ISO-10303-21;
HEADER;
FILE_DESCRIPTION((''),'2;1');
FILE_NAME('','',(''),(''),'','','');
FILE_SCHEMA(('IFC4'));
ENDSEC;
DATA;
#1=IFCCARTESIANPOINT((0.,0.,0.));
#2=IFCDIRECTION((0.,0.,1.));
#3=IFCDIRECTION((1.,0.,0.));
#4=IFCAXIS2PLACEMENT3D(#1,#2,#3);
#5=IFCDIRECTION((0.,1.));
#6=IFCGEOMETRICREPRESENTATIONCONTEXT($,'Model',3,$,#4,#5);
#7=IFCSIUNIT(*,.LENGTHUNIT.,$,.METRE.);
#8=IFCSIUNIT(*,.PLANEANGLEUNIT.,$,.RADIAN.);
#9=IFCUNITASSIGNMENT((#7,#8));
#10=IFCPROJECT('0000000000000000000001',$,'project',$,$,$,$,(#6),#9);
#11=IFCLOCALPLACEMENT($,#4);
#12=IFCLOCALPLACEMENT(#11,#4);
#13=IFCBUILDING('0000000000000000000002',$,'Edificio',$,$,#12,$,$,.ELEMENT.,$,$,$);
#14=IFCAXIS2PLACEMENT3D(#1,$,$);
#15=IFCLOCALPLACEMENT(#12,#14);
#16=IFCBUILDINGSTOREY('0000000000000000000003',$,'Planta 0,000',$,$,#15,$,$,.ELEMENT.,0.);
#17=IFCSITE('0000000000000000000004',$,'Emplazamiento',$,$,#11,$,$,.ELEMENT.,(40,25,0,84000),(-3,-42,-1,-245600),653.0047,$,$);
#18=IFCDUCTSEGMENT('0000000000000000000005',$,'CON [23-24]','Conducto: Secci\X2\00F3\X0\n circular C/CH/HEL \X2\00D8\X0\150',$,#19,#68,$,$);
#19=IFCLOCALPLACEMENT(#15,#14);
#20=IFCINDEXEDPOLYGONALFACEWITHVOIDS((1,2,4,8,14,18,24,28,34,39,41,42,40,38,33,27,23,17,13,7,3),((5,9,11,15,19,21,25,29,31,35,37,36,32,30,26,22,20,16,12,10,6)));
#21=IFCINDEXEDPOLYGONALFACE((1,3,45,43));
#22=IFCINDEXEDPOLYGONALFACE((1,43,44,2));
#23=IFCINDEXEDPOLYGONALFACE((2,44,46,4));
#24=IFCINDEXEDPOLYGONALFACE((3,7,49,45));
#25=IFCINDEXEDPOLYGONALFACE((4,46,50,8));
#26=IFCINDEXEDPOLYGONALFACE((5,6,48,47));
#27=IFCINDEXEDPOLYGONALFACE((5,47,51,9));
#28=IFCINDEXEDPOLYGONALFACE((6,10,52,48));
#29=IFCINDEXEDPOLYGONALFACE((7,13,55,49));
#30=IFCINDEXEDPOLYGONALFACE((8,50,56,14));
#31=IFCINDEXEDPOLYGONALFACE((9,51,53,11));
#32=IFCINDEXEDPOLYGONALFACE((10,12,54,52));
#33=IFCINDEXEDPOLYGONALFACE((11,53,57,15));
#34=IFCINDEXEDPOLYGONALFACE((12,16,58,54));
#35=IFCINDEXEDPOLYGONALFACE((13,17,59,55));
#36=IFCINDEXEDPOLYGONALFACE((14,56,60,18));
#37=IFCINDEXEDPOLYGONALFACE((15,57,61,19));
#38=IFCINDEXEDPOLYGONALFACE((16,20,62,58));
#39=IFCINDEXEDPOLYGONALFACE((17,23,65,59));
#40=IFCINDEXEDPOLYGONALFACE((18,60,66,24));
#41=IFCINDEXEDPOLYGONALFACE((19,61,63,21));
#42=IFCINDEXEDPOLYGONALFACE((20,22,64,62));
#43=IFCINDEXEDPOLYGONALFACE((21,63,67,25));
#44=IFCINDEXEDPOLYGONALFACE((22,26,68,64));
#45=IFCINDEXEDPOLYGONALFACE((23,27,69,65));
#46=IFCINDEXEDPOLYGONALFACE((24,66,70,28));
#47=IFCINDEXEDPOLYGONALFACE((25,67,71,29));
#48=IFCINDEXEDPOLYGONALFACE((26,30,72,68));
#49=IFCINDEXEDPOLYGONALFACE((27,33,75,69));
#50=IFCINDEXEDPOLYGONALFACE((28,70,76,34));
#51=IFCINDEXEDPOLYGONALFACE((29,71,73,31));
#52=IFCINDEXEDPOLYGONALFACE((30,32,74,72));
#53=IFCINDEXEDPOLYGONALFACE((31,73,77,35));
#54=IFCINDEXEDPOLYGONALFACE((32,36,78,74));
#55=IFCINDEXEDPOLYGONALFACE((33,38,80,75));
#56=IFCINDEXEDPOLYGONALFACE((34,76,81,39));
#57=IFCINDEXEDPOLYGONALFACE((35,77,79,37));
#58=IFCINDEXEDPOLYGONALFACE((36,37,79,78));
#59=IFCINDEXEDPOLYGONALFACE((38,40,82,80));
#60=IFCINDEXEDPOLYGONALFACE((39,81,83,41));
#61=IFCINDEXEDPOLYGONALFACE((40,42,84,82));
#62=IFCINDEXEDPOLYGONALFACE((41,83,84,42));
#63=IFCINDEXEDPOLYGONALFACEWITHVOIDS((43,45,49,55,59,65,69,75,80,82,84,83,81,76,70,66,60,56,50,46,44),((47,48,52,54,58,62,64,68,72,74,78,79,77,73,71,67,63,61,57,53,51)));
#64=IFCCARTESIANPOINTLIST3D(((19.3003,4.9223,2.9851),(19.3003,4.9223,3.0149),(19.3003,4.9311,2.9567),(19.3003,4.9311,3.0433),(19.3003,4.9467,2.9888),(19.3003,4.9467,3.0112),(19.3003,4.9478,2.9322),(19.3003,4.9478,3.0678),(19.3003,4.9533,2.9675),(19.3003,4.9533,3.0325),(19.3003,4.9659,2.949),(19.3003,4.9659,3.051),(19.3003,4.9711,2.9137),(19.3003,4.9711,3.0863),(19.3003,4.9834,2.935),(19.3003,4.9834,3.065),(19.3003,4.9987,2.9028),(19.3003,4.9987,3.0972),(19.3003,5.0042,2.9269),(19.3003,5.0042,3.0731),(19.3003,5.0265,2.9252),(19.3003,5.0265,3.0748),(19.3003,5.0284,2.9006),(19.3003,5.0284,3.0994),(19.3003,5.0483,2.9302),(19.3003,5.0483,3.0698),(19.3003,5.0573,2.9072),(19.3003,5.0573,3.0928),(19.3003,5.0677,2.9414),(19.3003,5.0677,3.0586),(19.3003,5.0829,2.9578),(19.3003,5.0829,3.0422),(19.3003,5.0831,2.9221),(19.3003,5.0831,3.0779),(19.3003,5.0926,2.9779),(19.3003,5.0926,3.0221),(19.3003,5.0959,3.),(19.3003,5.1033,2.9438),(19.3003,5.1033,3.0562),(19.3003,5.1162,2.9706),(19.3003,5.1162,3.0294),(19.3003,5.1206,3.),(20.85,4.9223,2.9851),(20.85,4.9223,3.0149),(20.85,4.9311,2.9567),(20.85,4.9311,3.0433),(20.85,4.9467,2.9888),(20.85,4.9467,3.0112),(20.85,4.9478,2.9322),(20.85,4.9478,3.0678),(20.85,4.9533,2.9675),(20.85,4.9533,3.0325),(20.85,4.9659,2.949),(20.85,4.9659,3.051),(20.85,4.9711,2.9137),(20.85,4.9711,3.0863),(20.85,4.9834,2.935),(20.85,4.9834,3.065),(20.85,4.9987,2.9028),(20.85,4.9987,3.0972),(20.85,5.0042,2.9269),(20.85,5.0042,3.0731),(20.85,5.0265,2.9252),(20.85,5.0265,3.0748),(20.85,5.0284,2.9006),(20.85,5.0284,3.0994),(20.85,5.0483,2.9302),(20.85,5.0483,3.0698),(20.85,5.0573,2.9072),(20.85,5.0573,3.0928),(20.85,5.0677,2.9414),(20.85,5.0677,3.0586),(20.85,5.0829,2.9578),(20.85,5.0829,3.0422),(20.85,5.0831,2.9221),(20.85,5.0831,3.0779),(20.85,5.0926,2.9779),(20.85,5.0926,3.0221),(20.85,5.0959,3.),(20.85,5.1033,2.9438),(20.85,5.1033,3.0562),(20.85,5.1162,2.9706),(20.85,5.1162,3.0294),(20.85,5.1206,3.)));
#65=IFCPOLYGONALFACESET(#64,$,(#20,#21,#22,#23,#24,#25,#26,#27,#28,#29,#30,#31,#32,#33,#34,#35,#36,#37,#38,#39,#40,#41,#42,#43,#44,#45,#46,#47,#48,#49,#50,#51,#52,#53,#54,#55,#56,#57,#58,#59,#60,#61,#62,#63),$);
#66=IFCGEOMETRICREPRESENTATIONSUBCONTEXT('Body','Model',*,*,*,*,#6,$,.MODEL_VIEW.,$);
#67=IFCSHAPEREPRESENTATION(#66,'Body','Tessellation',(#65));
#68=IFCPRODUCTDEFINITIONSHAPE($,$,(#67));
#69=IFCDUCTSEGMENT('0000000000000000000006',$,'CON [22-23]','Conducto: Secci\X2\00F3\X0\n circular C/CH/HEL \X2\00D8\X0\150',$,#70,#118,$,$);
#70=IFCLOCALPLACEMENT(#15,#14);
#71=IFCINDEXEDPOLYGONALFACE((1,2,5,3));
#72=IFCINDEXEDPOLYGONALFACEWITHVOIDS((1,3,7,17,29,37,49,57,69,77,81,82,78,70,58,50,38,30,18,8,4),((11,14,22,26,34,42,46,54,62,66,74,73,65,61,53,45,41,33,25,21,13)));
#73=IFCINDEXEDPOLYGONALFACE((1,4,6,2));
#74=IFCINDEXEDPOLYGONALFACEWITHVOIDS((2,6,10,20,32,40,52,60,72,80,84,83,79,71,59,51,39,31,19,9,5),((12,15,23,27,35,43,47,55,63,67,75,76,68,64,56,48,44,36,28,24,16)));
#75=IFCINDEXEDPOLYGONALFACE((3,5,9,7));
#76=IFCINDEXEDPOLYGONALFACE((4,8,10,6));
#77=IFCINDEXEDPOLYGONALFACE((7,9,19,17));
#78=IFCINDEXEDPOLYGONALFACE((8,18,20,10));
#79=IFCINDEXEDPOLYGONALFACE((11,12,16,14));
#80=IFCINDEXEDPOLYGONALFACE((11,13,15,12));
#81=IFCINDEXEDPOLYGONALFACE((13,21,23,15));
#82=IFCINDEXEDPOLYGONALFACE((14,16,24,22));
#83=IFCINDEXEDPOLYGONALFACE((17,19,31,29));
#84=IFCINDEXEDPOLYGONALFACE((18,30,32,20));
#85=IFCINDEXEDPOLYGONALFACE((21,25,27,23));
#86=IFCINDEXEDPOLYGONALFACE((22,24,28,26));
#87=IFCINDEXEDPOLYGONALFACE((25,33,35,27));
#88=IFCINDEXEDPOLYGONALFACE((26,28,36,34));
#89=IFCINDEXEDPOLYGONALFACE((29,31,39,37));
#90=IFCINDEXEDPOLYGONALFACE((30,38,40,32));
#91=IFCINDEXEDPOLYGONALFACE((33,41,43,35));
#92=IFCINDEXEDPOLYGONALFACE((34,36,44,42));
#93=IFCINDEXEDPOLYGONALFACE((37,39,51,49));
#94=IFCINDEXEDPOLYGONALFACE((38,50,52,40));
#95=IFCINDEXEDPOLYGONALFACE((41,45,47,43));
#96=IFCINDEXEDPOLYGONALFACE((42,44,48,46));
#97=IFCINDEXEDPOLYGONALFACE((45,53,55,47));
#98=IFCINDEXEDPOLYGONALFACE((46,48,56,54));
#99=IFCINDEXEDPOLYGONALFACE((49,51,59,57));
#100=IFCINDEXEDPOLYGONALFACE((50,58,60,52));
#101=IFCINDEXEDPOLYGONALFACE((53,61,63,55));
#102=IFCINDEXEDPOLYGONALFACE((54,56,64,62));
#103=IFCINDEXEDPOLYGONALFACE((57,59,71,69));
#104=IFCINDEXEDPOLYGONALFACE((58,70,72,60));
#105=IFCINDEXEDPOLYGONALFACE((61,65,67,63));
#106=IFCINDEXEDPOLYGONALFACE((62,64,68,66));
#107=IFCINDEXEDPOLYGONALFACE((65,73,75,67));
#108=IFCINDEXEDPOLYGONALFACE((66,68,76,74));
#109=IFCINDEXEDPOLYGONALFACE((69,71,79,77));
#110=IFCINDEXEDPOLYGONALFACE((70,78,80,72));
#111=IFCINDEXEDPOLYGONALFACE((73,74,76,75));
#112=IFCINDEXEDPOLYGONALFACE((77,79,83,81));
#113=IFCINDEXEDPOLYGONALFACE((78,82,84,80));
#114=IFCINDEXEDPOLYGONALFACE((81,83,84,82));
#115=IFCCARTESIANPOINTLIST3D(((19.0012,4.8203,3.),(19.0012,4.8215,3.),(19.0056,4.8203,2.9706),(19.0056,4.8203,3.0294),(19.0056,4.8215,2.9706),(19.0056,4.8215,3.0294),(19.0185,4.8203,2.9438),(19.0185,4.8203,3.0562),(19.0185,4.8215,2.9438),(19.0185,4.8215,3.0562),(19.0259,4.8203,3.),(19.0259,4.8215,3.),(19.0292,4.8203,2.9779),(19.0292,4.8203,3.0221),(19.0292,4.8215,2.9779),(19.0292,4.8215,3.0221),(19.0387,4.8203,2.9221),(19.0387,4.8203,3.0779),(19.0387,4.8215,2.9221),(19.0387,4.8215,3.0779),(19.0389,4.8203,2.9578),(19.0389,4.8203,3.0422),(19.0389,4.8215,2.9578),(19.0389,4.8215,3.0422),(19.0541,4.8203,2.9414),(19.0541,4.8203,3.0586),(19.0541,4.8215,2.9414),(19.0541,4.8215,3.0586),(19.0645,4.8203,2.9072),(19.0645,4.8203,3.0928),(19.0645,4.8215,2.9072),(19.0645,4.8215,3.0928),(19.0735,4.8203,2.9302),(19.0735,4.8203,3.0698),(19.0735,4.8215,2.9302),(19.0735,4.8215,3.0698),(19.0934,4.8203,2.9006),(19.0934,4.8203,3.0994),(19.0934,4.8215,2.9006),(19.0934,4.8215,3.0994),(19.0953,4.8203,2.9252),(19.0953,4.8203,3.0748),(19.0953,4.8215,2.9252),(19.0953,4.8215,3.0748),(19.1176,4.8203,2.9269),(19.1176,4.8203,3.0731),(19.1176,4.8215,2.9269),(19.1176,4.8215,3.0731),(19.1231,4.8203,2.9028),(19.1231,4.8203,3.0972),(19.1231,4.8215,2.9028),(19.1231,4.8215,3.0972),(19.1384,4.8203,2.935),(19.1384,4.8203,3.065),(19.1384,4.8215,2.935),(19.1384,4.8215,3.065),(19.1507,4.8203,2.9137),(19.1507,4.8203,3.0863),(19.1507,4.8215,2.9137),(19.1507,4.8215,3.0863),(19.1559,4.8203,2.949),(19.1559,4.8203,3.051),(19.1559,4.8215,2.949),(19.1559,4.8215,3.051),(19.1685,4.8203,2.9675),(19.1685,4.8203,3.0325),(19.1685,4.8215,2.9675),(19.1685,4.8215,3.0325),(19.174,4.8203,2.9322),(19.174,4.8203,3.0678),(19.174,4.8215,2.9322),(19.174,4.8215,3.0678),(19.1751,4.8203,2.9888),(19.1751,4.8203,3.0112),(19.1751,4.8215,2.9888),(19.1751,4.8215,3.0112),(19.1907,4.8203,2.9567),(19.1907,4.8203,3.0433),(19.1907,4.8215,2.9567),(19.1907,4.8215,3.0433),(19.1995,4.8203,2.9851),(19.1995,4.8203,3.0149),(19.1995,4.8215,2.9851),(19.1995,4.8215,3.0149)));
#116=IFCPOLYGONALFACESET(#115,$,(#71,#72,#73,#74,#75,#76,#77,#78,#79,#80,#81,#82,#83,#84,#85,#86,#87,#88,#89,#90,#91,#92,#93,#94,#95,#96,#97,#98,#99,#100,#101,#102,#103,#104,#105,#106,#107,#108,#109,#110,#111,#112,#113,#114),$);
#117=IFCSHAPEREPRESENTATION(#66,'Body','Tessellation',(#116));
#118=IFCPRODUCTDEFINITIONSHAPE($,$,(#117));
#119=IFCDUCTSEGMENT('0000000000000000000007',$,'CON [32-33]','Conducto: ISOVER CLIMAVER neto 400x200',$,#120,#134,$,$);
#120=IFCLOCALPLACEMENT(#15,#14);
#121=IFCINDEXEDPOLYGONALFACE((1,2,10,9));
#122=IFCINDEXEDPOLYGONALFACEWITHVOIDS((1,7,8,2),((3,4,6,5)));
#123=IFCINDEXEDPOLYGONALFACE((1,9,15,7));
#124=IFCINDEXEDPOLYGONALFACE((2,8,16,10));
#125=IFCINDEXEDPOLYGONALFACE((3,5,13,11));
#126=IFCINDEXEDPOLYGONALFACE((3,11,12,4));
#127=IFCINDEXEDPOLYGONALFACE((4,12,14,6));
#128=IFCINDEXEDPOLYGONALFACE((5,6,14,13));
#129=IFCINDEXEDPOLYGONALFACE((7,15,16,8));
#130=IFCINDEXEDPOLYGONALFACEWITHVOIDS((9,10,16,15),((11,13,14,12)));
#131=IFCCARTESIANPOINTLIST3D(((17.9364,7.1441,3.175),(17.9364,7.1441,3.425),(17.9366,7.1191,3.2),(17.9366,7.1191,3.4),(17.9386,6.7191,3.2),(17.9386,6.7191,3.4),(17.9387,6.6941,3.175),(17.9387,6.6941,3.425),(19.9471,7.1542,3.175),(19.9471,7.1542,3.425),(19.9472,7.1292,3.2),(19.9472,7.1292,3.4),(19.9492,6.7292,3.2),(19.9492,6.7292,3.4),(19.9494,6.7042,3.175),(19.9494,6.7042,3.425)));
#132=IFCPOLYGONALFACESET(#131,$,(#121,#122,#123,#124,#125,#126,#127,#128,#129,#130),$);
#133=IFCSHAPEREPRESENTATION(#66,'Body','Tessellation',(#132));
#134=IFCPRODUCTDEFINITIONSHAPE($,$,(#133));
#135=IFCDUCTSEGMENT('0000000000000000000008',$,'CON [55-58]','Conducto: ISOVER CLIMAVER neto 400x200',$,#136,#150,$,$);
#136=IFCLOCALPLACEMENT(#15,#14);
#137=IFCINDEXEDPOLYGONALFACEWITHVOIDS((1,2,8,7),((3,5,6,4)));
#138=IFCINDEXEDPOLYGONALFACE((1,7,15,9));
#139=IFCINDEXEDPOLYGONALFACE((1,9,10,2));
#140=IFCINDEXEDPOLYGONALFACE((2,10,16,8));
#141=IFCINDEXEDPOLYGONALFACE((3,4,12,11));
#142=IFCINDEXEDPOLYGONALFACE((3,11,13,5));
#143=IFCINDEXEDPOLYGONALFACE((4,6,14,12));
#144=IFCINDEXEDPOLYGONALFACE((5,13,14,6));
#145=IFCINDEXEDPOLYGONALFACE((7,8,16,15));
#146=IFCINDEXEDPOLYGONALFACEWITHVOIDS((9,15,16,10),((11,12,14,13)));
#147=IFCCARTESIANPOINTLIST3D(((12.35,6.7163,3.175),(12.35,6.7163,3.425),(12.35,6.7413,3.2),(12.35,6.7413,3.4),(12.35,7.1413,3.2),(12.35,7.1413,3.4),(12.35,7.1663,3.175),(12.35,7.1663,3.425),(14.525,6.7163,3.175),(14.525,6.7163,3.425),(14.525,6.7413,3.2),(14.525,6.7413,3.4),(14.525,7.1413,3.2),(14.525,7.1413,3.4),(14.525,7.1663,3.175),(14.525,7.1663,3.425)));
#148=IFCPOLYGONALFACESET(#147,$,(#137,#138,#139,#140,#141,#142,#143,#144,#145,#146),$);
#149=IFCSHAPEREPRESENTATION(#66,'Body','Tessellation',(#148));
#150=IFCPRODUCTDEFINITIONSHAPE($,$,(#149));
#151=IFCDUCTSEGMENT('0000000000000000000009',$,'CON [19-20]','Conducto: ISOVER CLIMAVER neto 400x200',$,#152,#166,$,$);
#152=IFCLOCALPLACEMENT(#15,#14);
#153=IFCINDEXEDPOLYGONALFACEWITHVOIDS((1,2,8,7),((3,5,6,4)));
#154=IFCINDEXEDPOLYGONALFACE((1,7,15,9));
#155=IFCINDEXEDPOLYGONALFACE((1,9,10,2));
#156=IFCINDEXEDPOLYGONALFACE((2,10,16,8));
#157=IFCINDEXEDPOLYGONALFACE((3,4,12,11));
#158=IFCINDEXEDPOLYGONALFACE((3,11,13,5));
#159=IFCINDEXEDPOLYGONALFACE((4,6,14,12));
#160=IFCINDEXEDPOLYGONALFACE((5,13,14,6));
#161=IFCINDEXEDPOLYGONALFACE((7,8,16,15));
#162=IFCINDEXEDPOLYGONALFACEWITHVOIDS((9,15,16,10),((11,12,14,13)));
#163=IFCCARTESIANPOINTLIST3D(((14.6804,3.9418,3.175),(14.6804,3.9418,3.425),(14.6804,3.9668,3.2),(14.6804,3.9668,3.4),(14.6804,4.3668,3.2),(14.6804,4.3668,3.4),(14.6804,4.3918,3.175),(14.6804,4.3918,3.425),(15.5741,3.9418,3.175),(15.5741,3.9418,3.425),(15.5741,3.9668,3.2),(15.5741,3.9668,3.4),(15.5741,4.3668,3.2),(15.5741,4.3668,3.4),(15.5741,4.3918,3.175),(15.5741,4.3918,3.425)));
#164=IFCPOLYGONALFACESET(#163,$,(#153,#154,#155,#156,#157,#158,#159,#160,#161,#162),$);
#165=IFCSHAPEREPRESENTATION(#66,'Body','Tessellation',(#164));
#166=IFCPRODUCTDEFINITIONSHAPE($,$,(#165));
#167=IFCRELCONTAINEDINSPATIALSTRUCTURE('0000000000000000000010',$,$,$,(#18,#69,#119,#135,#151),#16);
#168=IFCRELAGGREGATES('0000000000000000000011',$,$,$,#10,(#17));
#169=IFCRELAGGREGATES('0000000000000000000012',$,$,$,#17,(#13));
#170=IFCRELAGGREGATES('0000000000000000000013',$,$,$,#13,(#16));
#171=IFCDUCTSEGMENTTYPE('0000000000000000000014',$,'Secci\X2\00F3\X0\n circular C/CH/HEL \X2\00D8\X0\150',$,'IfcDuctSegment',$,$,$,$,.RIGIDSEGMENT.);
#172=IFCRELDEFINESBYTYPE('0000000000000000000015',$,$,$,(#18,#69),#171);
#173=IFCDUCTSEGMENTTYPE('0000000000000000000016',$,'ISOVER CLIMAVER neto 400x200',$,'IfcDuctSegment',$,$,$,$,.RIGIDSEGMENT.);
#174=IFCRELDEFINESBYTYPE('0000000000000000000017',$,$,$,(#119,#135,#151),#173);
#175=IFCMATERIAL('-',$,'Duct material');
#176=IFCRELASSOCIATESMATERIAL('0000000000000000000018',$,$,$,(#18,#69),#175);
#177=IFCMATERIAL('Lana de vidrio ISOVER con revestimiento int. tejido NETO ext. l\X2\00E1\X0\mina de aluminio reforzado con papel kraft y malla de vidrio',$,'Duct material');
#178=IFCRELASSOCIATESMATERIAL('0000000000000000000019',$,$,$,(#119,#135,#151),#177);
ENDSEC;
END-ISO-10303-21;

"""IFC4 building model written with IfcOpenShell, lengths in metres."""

from ifc_helpers import new_model, si_unit, direction, frame, origin, origin_with_axes, origin_2d_with_axis, place, context, subcontext, project, spatial, hollow_rectangle, hollow_circle, extrude, material, type_object, element, save


model = new_model("IFC4")

# Units and contexts
model_context = context("Model", 3, world=origin_with_axes(), true_north=direction((0.0, 1.0)))
body_context = subcontext(model_context, "Body", "Model", "MODEL_VIEW")
ifc_project = project(units=[si_unit("LENGTHUNIT", "METRE"), si_unit("PLANEANGLEUNIT", "RADIAN")], contexts=[model_context])

# Site, building, storey
site_placement = place(None, origin_with_axes())
site = spatial("IfcSite", under=ifc_project, at=site_placement, Name="Emplazamiento", CompositionType="ELEMENT", RefLatitude=(40, 25, 0, 84000), RefLongitude=(-3, -42, -1, -245600), RefElevation=653.0047)
building_placement = place(site_placement, origin_with_axes())
building = spatial("IfcBuilding", under=site, at=building_placement, Name="Edificio", CompositionType="ELEMENT")
storey_placement = place(building_placement, origin())
storey = spatial("IfcBuildingStorey", under=building, at=storey_placement, Name="Planta 0,000", CompositionType="ELEMENT", Elevation=0.0)

# Shared definitions
ifc_material_1 = material(Name="-", Category="Duct material")

# Shared definitions
ifc_material_2 = material(Name="Lana de vidrio ISOVER con revestimiento int. tejido NETO ext. lámina de aluminio reforzado con papel kraft y malla de vidrio", Category="Duct material")

# Duct segments
duct_segment_type_1 = type_object("IfcDuctSegmentType", Name="Sección circular C/CH/HEL Ø150", ApplicableOccurrence="IfcDuctSegment", PredefinedType="RIGIDSEGMENT")
duct_segment_1_placement = place(storey_placement, origin_with_axes())
element("IfcDuctSegment", 1, at=duct_segment_1_placement, inside=storey, type_object=duct_segment_type_1, material=ifc_material_1, Name="CON [23-24]", Description="Conducto: Sección circular C/CH/HEL Ø150", context=body_context, shape_type="SweptSolid", body=[
    extrude(hollow_circle(Radius=0.0997, WallThickness=0.0247, at=origin_2d_with_axis()), frame((19.3003, 5.0209, 3.0), z_axis=(1.0, 0.0, 0.0), x_axis=(0.0, 1.0, 0.0)), (0.0, 0.0, 1.0), 1.5497),
])
duct_segment_2_placement = place(storey_placement, origin_with_axes())
element("IfcDuctSegment", 2, at=duct_segment_2_placement, inside=storey, type_object=duct_segment_type_1, material=ifc_material_1, Name="CON [22-23]", Description="Conducto: Sección circular C/CH/HEL Ø150", context=body_context, shape_type="SweptSolid", body=[
    extrude(hollow_circle(Radius=0.0997, WallThickness=0.0247, at=origin_2d_with_axis()), frame((19.1009, 4.8203, 3.0), z_axis=(0.0, 1.0, 0.0), x_axis=(-1.0, 0.0, 0.0)), (0.0, 0.0, 1.0), 0.0012),
])
duct_segment_type_2 = type_object("IfcDuctSegmentType", Name="ISOVER CLIMAVER neto 400x200", ApplicableOccurrence="IfcDuctSegment", PredefinedType="RIGIDSEGMENT")
duct_segment_3_placement = place(storey_placement, origin_with_axes())
element("IfcDuctSegment", 3, at=duct_segment_3_placement, inside=storey, type_object=duct_segment_type_2, material=ifc_material_2, Name="CON [32-33]", Description="Conducto: ISOVER CLIMAVER neto 400x200", context=body_context, shape_type="SweptSolid", body=[
    extrude(hollow_rectangle(XDim=0.45, YDim=0.25, WallThickness=0.025, at=origin_2d_with_axis()), frame((17.9376, 6.9191, 3.3), z_axis=(0.999987, 0.005013, 0.0), x_axis=(-0.005013, 0.999987, 0.0)), (0.0, 0.0, 1.0), 2.0107),
])
duct_segment_4_placement = place(storey_placement, origin_with_axes())
element("IfcDuctSegment", 4, at=duct_segment_4_placement, inside=storey, type_object=duct_segment_type_2, material=ifc_material_2, Name="CON [55-58]", Description="Conducto: ISOVER CLIMAVER neto 400x200", context=body_context, shape_type="SweptSolid", body=[
    extrude(hollow_rectangle(XDim=0.45, YDim=0.25, WallThickness=0.025, at=origin_2d_with_axis()), frame((14.525, 6.9413, 3.3), z_axis=(-1.0, 0.0, 0.0), x_axis=(0.0, -1.0, 0.0)), (0.0, 0.0, 1.0), 2.175),
])
duct_segment_5_placement = place(storey_placement, origin_with_axes())
element("IfcDuctSegment", 5, at=duct_segment_5_placement, inside=storey, type_object=duct_segment_type_2, material=ifc_material_2, Name="CON [19-20]", Description="Conducto: ISOVER CLIMAVER neto 400x200", context=body_context, shape_type="SweptSolid", body=[
    extrude(hollow_rectangle(XDim=0.45, YDim=0.25, WallThickness=0.025, at=origin_2d_with_axis()), frame((15.5741, 4.1668, 3.3), z_axis=(-1.0, 0.0, 0.0), x_axis=(0.0, -1.0, 0.0)), (0.0, 0.0, 1.0), 0.8938),
])

save(model, "model.ifc")
